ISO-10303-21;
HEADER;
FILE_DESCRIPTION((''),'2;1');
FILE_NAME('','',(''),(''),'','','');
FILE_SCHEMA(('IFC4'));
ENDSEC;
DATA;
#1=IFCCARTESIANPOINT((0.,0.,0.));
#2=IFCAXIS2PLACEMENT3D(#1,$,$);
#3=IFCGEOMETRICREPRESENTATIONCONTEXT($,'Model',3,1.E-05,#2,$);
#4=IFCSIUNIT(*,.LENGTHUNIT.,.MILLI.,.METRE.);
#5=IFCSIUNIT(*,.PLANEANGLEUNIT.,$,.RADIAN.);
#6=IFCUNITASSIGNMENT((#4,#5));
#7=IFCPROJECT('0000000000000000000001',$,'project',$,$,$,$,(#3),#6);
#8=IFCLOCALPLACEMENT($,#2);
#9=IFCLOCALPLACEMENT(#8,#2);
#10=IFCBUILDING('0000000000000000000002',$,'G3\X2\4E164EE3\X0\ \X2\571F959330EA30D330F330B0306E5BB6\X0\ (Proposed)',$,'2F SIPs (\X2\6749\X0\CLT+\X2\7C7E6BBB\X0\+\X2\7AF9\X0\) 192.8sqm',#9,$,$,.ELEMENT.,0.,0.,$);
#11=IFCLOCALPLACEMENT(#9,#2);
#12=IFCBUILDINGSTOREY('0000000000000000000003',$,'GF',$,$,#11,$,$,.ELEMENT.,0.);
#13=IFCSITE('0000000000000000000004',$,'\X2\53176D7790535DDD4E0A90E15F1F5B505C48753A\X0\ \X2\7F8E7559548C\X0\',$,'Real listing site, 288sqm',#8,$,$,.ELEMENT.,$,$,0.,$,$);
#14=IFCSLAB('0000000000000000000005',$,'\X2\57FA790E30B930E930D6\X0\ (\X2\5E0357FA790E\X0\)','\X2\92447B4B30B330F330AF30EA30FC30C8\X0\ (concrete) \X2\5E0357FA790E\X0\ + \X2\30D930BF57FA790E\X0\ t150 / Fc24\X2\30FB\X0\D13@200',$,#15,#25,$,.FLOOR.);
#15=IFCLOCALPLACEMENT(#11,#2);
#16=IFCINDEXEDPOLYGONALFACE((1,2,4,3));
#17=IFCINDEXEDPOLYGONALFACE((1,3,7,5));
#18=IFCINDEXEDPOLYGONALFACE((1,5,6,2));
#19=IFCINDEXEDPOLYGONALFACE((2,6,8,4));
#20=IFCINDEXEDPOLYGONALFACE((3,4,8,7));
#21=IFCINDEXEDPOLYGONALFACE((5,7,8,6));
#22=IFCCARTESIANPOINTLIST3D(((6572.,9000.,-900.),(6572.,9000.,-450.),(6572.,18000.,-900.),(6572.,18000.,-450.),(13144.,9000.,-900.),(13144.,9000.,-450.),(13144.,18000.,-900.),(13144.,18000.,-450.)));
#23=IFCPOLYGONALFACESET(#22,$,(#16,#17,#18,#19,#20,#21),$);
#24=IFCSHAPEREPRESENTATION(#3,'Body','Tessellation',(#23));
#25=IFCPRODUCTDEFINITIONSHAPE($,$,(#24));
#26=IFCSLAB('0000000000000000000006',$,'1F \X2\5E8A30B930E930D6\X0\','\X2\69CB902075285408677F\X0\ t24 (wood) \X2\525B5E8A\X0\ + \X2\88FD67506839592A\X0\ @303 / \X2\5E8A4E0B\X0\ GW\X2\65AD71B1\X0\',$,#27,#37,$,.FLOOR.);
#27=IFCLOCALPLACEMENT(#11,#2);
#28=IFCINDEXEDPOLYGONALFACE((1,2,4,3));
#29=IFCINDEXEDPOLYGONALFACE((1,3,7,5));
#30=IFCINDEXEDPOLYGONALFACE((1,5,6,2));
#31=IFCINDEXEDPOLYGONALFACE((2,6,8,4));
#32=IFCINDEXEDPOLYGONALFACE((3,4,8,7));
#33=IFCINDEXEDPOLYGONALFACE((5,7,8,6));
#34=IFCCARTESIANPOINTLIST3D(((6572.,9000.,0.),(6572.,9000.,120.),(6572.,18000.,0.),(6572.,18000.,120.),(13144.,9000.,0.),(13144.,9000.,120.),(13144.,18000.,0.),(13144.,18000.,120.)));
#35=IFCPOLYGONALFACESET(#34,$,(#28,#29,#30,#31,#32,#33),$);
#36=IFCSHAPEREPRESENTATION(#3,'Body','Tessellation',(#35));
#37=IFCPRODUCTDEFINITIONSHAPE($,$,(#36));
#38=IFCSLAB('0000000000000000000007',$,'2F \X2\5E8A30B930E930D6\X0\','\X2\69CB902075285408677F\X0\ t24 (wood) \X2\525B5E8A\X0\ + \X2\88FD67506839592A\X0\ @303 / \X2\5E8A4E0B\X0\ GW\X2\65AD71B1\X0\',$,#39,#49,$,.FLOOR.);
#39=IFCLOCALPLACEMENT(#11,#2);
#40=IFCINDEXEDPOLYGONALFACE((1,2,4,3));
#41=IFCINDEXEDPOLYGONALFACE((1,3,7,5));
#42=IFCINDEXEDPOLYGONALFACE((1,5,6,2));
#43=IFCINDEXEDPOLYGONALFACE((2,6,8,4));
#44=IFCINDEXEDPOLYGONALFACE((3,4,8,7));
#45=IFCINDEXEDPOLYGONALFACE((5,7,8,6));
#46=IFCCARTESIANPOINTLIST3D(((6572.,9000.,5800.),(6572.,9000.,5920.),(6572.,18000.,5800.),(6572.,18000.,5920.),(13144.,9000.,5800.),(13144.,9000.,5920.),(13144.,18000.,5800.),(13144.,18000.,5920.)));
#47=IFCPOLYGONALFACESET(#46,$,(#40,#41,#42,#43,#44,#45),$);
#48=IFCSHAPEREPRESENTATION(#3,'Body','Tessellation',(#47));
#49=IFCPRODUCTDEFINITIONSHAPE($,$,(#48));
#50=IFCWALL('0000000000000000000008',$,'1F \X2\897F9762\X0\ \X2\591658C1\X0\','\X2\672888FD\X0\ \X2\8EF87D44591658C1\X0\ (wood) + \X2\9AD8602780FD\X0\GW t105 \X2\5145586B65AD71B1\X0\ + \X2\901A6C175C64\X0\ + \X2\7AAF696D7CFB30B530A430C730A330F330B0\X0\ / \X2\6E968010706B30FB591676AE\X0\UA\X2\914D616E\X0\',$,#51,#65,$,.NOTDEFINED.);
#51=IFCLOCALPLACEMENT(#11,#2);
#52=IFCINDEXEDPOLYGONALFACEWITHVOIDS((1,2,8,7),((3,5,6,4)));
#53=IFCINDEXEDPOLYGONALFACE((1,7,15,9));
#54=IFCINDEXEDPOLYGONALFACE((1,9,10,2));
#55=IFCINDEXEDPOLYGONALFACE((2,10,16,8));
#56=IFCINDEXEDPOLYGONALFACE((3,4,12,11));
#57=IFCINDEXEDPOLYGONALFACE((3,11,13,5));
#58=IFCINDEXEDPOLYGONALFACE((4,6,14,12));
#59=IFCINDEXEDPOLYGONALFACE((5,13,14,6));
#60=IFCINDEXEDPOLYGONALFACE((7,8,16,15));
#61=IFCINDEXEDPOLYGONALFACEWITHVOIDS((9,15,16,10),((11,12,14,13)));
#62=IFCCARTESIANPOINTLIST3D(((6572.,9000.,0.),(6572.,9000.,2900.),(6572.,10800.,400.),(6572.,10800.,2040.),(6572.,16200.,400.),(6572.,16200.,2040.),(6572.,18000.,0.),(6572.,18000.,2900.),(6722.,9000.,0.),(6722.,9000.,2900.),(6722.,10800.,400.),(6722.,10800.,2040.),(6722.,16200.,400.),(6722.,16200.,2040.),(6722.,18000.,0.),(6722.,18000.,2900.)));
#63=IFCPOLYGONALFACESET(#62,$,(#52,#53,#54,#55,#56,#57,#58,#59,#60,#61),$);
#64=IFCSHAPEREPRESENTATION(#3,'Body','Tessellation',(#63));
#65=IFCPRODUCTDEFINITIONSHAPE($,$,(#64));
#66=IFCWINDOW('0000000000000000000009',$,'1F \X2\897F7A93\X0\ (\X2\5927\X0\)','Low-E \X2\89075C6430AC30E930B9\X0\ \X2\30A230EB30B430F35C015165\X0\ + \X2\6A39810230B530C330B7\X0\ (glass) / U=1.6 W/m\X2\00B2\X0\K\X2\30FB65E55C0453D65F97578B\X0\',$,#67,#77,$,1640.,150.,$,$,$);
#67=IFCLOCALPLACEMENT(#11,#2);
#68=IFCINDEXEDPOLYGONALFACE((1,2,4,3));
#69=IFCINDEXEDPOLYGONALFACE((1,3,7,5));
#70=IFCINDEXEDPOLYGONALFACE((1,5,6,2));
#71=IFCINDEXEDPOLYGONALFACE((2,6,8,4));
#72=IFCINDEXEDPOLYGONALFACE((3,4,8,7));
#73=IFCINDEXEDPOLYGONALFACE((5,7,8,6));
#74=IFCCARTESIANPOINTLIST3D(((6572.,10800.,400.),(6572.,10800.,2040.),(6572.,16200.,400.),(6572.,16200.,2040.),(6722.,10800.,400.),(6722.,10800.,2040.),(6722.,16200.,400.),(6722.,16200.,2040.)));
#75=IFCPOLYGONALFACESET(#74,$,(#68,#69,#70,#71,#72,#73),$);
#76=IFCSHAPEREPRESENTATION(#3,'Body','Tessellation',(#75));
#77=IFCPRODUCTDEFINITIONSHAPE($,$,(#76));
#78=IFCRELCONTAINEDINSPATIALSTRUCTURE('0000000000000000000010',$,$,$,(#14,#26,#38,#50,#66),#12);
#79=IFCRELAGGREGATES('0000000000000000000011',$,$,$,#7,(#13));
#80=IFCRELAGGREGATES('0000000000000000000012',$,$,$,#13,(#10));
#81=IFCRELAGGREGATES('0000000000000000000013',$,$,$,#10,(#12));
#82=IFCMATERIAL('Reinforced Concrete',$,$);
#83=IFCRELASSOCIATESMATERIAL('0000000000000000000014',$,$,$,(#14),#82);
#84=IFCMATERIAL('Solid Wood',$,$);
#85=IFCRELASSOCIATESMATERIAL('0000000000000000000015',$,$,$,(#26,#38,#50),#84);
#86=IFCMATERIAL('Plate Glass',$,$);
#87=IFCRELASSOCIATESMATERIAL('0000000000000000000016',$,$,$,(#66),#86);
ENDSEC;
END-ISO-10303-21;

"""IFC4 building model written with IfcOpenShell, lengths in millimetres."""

from ifc_helpers import new_model, si_unit, frame, frame_2d, origin, place, context, project, spatial, rectangle, extrude, material, element, fill, save


model = new_model("IFC4")

# Units and contexts
model_context = context("Model", 3, precision=1e-05, world=origin())
ifc_project = project(units=[si_unit("LENGTHUNIT", "METRE", prefix="MILLI"), si_unit("PLANEANGLEUNIT", "RADIAN")], contexts=[model_context])

# Site, building, storey
site_placement = place(None, origin())
site = spatial("IfcSite", under=ifc_project, at=site_placement, Name="北海道川上郡弟子屈町 美留和", ObjectType="Real listing site, 288sqm", CompositionType="ELEMENT", RefElevation=0.0)
building_placement = place(site_placement, origin())
building = spatial("IfcBuilding", under=site, at=building_placement, Name="G3世代 土間リビングの家 (Proposed)", ObjectType="2F SIPs (杉CLT+籾殻+竹) 192.8sqm", CompositionType="ELEMENT", ElevationOfRefHeight=0.0, ElevationOfTerrain=0.0)
storey_placement = place(building_placement, origin())
storey = spatial("IfcBuildingStorey", under=building, at=storey_placement, Name="GF", CompositionType="ELEMENT", Elevation=0.0)

# Slabs
ifc_material_1 = material(Name="Reinforced Concrete")
slab_1_placement = place(storey_placement, frame((3286.0, 4500.0, -450.0)))
element("IfcSlab", 1, at=slab_1_placement, inside=storey, material=ifc_material_1, Name="基礎スラブ (布基礎)", Description="鉄筋コンクリート (concrete) 布基礎 + ベタ基礎 t150 / Fc24・D13@200", PredefinedType="FLOOR", context=model_context, shape_type="SweptSolid", body=[
    extrude(rectangle(XDim=6572.0, YDim=9000.0, at=frame_2d((3286.0, 4500.0))), frame((3286.0, 4500.0, -450.0)), (0.0, 0.0, 1.0), 450.0),
])
ifc_material_2 = material(Name="Solid Wood")
slab_2_placement = place(storey_placement, frame((3286.0, 4500.0, 0.0)))
element("IfcSlab", 2, at=slab_2_placement, inside=storey, material=ifc_material_2, Name="1F 床スラブ", Description="構造用合板 t24 (wood) 剛床 + 製材根太 @303 / 床下 GW断熱", PredefinedType="FLOOR", context=model_context, shape_type="SweptSolid", body=[
    extrude(rectangle(XDim=6572.0, YDim=9000.0, at=frame_2d((3286.0, 4500.0))), frame((3286.0, 4500.0, 0.0)), (0.0, 0.0, 1.0), 120.0),
])
slab_3_placement = place(storey_placement, frame((3286.0, 4500.0, 2900.0)))
element("IfcSlab", 3, at=slab_3_placement, inside=storey, material=ifc_material_2, Name="2F 床スラブ", Description="構造用合板 t24 (wood) 剛床 + 製材根太 @303 / 床下 GW断熱", PredefinedType="FLOOR", context=model_context, shape_type="SweptSolid", body=[
    extrude(rectangle(XDim=6572.0, YDim=9000.0, at=frame_2d((3286.0, 4500.0))), frame((3286.0, 4500.0, 2900.0)), (0.0, 0.0, 1.0), 120.0),
])

# Shared definitions
ifc_material_3 = material(Name="Plate Glass")

# Wall, opening, window
wall_1_placement = place(storey_placement, frame((3286.0, 4500.0, 0.0)))
wall_1 = element("IfcWall", 4, at=wall_1_placement, inside=storey, material=ifc_material_2, Name="1F 西面 外壁", Description="木製 軸組外壁 (wood) + 高性能GW t105 充填断熱 + 通気層 + 窯業系サイディング / 準耐火・外皮UA配慮", PredefinedType="NOTDEFINED", context=model_context, shape_type="SweptSolid", body=[
    extrude(rectangle(XDim=150.0, YDim=9000.0, at=frame_2d((75.0, 4500.0))), frame((3286.0, 4500.0, 0.0)), (0.0, 0.0, 1.0), 2900.0),
])
opening_1_placement = place(storey_placement, frame((3286.0, 5400.0, 200.0)))
opening_1 = element("IfcOpeningElement", 5, at=opening_1_placement, cuts=wall_1, PredefinedType="NOTDEFINED", context=model_context, shape_type="SweptSolid", body=[
    extrude(rectangle(XDim=150.0, YDim=5400.0, at=frame_2d((75.0, 2700.0))), frame((3286.0, 5400.0, 200.0)), (0.0, 0.0, 1.0), 1640.0),
])
window_1_placement = place(storey_placement, frame((3286.0, 5400.0, 200.0)))
window_1 = element("IfcWindow", 6, at=window_1_placement, inside=storey, material=ifc_material_3, Name="1F 西窓 (大)", Description="Low-E 複層ガラス アルゴン封入 + 樹脂サッシ (glass) / U=1.6 W/m²K・日射取得型", OverallHeight=1640.0, OverallWidth=150.0, context=model_context, shape_type="SweptSolid", body=[
    extrude(rectangle(XDim=150.0, YDim=5400.0, at=frame_2d((75.0, 2700.0))), frame((3286.0, 5400.0, 200.0)), (0.0, 0.0, 1.0), 1640.0),
])
fill(opening_1, window_1)

save(model, "model.ifc")
